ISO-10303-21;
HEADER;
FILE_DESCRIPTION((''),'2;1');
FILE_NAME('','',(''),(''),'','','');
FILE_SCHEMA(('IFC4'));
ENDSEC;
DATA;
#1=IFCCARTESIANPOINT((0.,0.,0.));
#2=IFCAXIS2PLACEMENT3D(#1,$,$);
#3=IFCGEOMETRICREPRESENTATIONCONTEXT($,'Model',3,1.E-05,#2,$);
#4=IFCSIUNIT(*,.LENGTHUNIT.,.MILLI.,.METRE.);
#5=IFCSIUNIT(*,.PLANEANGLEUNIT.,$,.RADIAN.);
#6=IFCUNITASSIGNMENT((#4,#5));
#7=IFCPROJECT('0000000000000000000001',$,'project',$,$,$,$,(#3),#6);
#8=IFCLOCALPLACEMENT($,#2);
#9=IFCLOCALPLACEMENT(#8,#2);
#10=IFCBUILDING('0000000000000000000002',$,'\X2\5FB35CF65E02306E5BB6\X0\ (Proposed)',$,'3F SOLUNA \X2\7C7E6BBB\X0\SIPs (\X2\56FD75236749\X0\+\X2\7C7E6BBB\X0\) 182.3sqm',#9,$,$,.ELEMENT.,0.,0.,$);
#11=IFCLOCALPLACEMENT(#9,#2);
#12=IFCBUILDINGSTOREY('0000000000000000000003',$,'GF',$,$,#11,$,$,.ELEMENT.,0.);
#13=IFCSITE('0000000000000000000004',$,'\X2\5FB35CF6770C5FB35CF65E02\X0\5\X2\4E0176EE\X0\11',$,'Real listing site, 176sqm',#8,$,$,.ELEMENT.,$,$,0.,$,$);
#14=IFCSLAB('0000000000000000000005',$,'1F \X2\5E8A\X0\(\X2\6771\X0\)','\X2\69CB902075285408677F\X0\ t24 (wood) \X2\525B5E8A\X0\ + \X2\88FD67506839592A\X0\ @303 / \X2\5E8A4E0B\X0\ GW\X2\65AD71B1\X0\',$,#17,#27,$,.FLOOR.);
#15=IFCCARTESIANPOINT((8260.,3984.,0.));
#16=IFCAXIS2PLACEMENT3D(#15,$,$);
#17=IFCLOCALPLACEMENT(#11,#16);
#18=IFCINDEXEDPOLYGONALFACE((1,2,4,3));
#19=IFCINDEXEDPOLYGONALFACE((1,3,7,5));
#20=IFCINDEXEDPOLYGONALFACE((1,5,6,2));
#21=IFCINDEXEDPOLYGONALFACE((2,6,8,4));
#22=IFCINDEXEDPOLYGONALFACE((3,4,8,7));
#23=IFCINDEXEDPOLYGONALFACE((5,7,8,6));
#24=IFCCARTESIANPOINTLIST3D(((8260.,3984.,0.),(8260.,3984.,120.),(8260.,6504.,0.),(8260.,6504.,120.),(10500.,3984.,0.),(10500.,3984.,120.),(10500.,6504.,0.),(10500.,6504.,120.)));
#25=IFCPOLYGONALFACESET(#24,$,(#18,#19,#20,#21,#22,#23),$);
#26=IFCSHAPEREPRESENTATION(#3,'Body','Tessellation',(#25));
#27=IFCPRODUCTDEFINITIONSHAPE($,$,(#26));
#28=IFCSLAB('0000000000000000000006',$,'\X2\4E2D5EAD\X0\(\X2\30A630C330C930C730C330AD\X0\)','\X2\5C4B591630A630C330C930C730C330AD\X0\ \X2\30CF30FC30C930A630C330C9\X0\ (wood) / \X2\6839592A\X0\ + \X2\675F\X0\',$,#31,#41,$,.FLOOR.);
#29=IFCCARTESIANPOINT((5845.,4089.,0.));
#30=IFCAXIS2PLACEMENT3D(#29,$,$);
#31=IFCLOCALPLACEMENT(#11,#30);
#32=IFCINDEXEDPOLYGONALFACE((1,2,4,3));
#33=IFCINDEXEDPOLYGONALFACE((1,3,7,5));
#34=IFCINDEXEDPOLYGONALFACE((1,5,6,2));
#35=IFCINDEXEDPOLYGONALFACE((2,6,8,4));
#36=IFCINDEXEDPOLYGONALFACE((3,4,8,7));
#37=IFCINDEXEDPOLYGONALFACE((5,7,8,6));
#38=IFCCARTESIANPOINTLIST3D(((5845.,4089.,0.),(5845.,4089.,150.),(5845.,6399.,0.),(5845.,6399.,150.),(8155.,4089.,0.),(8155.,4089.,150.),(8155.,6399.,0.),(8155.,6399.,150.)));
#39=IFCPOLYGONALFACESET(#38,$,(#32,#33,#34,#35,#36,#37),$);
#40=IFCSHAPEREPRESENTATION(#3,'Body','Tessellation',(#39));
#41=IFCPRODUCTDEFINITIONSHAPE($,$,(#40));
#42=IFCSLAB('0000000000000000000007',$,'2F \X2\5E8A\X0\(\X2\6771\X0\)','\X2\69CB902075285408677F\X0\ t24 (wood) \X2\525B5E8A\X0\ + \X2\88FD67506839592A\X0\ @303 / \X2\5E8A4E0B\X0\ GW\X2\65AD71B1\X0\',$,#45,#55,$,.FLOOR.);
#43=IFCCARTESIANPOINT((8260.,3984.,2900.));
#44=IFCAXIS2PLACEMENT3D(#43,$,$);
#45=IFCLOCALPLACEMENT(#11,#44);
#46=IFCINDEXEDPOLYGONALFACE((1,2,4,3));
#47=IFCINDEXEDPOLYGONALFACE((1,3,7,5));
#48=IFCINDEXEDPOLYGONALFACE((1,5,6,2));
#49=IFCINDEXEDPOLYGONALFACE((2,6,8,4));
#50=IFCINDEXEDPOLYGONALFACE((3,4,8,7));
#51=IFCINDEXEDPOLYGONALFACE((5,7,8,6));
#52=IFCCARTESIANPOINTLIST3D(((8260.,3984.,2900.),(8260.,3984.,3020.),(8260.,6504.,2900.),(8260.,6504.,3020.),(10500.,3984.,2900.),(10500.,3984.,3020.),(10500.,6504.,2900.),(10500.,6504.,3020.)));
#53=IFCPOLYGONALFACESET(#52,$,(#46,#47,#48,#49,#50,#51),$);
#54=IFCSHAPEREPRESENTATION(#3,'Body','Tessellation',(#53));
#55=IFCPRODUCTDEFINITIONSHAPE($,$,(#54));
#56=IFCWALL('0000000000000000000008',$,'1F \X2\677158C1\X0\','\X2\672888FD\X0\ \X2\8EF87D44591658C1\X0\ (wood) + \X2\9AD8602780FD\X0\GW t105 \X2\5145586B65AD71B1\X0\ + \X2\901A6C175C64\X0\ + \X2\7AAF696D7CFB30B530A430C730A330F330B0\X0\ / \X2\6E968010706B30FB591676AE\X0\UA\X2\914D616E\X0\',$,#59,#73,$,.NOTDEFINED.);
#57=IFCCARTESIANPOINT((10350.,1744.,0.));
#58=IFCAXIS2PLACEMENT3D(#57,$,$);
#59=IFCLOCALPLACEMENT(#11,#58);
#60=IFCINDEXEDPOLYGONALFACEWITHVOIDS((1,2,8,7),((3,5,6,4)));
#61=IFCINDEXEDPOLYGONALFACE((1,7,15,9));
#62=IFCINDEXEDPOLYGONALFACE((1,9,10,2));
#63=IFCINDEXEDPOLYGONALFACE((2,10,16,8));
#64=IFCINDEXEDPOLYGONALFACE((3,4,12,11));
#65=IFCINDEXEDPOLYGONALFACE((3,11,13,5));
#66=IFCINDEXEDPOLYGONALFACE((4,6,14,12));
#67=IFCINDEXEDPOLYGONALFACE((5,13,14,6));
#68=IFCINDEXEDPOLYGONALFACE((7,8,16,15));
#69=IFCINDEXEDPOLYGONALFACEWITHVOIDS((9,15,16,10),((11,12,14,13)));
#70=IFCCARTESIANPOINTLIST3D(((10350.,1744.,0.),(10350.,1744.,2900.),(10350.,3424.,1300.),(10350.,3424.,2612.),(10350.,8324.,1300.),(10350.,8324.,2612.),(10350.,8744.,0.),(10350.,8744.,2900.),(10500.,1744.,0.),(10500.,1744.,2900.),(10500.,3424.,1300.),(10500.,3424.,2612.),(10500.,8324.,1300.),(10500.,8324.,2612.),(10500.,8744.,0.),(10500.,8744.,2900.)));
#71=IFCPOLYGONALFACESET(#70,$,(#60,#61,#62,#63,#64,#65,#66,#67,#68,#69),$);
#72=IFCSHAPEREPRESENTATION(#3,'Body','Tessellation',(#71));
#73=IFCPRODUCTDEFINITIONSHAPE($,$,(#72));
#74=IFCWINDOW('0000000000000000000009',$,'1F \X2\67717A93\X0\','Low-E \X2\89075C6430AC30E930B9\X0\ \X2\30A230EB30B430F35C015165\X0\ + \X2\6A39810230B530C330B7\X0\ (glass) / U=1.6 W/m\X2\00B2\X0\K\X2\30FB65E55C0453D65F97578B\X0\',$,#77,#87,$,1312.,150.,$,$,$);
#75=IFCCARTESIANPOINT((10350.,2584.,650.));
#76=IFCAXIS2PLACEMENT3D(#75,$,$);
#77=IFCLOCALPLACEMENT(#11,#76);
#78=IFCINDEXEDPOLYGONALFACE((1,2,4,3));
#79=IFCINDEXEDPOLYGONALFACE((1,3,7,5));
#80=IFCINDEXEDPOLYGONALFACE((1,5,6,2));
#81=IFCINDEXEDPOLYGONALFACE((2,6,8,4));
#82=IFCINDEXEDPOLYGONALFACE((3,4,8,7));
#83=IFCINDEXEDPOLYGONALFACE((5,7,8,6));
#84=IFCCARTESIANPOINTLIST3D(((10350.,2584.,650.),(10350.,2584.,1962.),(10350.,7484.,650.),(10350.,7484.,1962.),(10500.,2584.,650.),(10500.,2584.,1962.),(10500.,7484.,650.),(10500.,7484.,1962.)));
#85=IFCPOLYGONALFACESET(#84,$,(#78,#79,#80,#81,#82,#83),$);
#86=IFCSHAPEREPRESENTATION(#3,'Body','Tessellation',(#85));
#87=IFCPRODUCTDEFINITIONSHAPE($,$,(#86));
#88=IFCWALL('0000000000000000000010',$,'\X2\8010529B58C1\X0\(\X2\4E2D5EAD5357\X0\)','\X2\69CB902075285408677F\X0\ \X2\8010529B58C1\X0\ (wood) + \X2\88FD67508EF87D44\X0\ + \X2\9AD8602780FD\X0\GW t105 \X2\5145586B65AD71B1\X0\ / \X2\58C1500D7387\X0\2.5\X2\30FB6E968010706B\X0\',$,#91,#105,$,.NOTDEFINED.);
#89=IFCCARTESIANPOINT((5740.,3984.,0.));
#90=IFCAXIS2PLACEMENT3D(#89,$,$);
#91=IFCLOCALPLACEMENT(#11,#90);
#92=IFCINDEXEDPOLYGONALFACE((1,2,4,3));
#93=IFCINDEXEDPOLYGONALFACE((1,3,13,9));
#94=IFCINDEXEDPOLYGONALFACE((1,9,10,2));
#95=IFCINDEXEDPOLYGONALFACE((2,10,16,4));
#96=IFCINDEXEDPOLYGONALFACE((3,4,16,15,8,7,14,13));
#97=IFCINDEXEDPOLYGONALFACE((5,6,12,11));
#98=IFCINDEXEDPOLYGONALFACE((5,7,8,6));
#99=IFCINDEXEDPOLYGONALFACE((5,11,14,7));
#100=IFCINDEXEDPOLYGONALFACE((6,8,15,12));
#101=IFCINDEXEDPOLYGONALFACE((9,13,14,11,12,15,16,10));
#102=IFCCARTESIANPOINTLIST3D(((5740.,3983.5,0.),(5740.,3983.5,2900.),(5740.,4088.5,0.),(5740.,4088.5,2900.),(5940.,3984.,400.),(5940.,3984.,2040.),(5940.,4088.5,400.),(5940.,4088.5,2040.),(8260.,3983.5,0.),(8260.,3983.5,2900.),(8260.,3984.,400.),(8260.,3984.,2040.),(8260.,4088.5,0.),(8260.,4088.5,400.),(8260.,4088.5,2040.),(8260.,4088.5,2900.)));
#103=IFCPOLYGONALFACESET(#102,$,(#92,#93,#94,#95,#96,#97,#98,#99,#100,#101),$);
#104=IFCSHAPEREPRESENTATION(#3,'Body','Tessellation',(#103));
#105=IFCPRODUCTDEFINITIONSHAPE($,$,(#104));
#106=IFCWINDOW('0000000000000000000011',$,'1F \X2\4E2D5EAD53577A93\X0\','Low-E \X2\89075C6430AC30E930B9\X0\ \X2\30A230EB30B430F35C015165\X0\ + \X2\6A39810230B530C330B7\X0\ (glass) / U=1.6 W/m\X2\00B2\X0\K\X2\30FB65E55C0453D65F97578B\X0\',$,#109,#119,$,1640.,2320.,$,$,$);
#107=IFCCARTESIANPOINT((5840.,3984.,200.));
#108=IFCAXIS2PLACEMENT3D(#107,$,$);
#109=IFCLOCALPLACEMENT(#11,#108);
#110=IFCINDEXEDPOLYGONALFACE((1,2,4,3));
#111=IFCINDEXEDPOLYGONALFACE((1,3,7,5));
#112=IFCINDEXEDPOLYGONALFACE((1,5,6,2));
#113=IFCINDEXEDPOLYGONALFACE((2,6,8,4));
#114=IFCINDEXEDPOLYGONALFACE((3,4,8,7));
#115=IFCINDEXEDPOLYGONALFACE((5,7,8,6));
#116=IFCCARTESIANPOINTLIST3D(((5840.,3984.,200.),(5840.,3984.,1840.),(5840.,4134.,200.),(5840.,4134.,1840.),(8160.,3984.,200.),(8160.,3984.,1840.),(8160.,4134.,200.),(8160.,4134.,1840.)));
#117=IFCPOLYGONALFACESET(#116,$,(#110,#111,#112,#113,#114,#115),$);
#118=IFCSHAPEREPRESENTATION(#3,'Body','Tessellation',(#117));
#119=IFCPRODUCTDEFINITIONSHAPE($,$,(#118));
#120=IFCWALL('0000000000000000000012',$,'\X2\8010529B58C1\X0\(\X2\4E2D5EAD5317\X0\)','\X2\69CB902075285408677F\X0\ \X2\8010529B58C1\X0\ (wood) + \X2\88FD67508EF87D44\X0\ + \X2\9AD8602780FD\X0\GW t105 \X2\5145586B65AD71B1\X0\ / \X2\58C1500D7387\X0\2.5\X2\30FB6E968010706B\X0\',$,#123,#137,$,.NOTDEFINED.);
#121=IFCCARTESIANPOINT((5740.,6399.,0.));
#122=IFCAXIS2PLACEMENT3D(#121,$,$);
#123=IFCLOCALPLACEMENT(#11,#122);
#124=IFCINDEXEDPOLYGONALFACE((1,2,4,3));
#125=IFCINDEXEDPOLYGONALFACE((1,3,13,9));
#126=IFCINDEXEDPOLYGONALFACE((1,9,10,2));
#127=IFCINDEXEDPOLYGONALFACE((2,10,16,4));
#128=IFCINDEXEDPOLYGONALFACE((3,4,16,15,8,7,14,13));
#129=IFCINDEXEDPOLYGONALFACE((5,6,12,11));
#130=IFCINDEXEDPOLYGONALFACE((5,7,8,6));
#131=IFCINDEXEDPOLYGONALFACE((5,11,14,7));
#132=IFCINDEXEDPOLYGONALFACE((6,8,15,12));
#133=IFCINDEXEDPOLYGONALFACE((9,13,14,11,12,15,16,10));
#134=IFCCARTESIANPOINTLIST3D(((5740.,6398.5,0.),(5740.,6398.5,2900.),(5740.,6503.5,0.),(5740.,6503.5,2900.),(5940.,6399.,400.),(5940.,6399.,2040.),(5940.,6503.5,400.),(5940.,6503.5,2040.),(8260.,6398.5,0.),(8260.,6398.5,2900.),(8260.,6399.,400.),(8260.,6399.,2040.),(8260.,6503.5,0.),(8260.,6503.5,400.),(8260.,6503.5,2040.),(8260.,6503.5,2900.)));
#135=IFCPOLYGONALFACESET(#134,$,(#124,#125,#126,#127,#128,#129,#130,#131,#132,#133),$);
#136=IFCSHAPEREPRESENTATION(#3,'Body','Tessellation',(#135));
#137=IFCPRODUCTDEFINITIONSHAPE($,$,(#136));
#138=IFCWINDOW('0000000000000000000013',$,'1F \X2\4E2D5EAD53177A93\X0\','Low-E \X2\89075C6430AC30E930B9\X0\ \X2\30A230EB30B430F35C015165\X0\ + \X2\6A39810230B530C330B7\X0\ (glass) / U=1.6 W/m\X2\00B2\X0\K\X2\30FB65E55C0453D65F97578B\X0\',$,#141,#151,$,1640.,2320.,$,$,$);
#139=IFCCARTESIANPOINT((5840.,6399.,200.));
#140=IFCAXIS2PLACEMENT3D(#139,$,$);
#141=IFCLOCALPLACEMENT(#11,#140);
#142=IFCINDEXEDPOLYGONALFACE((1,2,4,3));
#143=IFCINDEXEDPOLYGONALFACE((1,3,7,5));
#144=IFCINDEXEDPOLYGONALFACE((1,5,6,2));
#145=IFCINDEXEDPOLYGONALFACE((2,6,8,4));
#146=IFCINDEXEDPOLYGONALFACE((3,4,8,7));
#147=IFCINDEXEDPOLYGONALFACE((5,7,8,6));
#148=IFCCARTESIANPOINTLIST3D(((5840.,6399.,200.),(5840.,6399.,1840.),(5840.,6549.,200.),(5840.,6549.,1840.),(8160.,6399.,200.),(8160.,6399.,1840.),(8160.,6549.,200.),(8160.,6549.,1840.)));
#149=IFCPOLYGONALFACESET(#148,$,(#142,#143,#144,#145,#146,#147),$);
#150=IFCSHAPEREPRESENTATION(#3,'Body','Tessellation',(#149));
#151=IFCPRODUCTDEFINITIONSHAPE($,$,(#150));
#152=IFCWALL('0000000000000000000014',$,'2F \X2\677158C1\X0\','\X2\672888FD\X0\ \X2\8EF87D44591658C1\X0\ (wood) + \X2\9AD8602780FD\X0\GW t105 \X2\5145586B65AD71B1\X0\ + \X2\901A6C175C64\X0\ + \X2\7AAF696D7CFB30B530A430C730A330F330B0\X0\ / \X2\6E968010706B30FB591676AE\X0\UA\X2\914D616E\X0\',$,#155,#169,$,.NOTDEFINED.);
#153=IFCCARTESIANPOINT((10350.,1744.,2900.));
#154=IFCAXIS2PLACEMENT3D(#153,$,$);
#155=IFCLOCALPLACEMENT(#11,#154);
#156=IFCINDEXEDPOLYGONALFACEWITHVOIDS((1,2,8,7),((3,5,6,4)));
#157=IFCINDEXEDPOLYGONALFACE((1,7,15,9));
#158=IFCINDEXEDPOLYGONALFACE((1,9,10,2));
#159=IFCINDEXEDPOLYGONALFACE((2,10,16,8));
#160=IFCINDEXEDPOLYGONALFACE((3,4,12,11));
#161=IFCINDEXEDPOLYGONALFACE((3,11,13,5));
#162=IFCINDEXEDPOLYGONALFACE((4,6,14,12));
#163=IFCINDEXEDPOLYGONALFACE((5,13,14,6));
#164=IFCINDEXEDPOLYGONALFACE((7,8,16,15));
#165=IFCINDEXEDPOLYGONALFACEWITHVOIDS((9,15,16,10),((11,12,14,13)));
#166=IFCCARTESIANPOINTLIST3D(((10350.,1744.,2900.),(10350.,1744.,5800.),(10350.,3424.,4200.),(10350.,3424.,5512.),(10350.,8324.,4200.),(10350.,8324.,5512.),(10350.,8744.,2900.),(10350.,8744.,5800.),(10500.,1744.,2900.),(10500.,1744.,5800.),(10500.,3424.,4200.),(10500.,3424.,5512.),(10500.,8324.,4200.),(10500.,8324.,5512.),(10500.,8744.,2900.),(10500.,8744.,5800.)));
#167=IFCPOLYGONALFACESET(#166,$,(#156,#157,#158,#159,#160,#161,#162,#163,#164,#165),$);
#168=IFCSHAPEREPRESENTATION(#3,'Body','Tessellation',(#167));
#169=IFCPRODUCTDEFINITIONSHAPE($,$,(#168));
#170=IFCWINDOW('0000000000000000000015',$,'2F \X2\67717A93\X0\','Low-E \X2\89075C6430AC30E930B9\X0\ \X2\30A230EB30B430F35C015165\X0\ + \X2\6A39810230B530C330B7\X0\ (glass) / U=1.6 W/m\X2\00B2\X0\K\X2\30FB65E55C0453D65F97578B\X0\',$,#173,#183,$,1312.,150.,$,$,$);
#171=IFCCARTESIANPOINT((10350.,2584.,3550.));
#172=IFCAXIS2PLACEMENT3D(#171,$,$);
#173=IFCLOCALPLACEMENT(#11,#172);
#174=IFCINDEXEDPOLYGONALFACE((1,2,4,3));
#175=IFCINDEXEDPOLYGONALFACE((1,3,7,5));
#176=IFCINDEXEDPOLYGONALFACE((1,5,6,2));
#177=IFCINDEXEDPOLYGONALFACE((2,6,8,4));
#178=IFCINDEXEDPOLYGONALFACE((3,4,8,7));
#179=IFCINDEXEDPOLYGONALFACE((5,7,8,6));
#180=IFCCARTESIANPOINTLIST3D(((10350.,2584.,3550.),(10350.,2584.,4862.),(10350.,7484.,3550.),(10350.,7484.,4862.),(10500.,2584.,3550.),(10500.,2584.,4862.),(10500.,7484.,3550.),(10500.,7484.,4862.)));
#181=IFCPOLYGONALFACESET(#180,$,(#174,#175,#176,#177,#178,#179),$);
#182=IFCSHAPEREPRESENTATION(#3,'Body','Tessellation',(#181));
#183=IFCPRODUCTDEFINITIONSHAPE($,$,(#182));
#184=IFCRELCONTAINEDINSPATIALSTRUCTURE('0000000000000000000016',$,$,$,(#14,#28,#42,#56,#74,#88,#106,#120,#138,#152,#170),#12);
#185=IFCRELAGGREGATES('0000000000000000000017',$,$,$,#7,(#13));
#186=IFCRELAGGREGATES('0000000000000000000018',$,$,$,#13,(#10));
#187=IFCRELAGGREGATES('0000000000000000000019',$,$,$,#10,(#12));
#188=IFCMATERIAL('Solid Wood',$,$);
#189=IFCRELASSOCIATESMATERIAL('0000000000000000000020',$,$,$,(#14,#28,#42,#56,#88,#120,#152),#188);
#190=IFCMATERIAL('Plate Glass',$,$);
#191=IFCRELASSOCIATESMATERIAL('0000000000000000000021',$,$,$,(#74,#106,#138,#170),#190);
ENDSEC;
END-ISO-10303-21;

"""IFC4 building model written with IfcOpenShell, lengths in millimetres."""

from ifc_helpers import new_model, si_unit, frame, frame_2d, origin, place, context, project, spatial, rectangle, extrude, material, element, fill, save


model = new_model("IFC4")

# Units and contexts
model_context = context("Model", 3, precision=1e-05, world=origin())
ifc_project = project(units=[si_unit("LENGTHUNIT", "METRE", prefix="MILLI"), si_unit("PLANEANGLEUNIT", "RADIAN")], contexts=[model_context])

# Site, building, storey
site_placement = place(None, origin())
site = spatial("IfcSite", under=ifc_project, at=site_placement, Name="徳島県徳島市5丁目11", ObjectType="Real listing site, 176sqm", CompositionType="ELEMENT", RefElevation=0.0)
building_placement = place(site_placement, origin())
building = spatial("IfcBuilding", under=site, at=building_placement, Name="徳島市の家 (Proposed)", ObjectType="3F SOLUNA 籾殻SIPs (国産杉+籾殻) 182.3sqm", CompositionType="ELEMENT", ElevationOfRefHeight=0.0, ElevationOfTerrain=0.0)
storey_placement = place(building_placement, origin())
storey = spatial("IfcBuildingStorey", under=building, at=storey_placement, Name="GF", CompositionType="ELEMENT", Elevation=0.0)

# Slabs
ifc_material_1 = material(Name="Solid Wood")
slab_1_placement = place(storey_placement, frame((8260.0, 3984.0, 0.0)))
element("IfcSlab", 1, at=slab_1_placement, inside=storey, material=ifc_material_1, Name="1F 床(東)", Description="構造用合板 t24 (wood) 剛床 + 製材根太 @303 / 床下 GW断熱", PredefinedType="FLOOR", context=model_context, shape_type="SweptSolid", body=[
    extrude(rectangle(XDim=2240.0, YDim=2520.0, at=frame_2d((1120.0, 1260.0))), frame((8260.0, 3984.0, 0.0)), (0.0, 0.0, 1.0), 120.0),
])
slab_2_placement = place(storey_placement, frame((5845.0, 4089.0, 0.0)))
element("IfcSlab", 2, at=slab_2_placement, inside=storey, material=ifc_material_1, Name="中庭(ウッドデッキ)", Description="屋外ウッドデッキ ハードウッド (wood) / 根太 + 束", PredefinedType="FLOOR", context=model_context, shape_type="SweptSolid", body=[
    extrude(rectangle(XDim=2310.0, YDim=2310.0, at=frame_2d((1155.0, 1155.0))), frame((5845.0, 4089.0, 0.0)), (0.0, 0.0, 1.0), 150.0),
])
slab_3_placement = place(storey_placement, frame((8260.0, 3984.0, 2900.0)))
element("IfcSlab", 3, at=slab_3_placement, inside=storey, material=ifc_material_1, Name="2F 床(東)", Description="構造用合板 t24 (wood) 剛床 + 製材根太 @303 / 床下 GW断熱", PredefinedType="FLOOR", context=model_context, shape_type="SweptSolid", body=[
    extrude(rectangle(XDim=2240.0, YDim=2520.0, at=frame_2d((1120.0, 1260.0))), frame((8260.0, 3984.0, 2900.0)), (0.0, 0.0, 1.0), 120.0),
])

# Walls, openings, windows
wall_1_placement = place(storey_placement, frame((10350.0, 1744.0, 0.0)))
wall_1 = element("IfcWall", 4, at=wall_1_placement, inside=storey, material=ifc_material_1, Name="1F 東壁", Description="木製 軸組外壁 (wood) + 高性能GW t105 充填断熱 + 通気層 + 窯業系サイディング / 準耐火・外皮UA配慮", PredefinedType="NOTDEFINED", context=model_context, shape_type="SweptSolid", body=[
    extrude(rectangle(XDim=150.0, YDim=7000.0, at=frame_2d((75.0, 3500.0))), frame((10350.0, 1744.0, 0.0)), (0.0, 0.0, 1.0), 2900.0),
])
opening_1_placement = place(storey_placement, frame((10350.0, 2584.0, 650.0)))
opening_1 = element("IfcOpeningElement", 5, at=opening_1_placement, cuts=wall_1, PredefinedType="NOTDEFINED", context=model_context, shape_type="SweptSolid", body=[
    extrude(rectangle(XDim=150.0, YDim=4900.0, at=frame_2d((75.0, 2450.0))), frame((10350.0, 2584.0, 650.0)), (0.0, 0.0, 1.0), 1312.0),
])
ifc_material_2 = material(Name="Plate Glass")
window_1_placement = place(storey_placement, frame((10350.0, 2584.0, 650.0)))
window_1 = element("IfcWindow", 6, at=window_1_placement, inside=storey, material=ifc_material_2, Name="1F 東窓", Description="Low-E 複層ガラス アルゴン封入 + 樹脂サッシ (glass) / U=1.6 W/m²K・日射取得型", OverallHeight=1312.0, OverallWidth=150.0, context=model_context, shape_type="SweptSolid", body=[
    extrude(rectangle(XDim=150.0, YDim=4900.0, at=frame_2d((75.0, 2450.0))), frame((10350.0, 2584.0, 650.0)), (0.0, 0.0, 1.0), 1312.0),
])
fill(opening_1, window_1)
wall_2_placement = place(storey_placement, frame((5740.0, 3984.0, 0.0)))
wall_2 = element("IfcWall", 7, at=wall_2_placement, inside=storey, material=ifc_material_1, Name="耐力壁(中庭南)", Description="構造用合板 耐力壁 (wood) + 製材軸組 + 高性能GW t105 充填断熱 / 壁倍率2.5・準耐火", PredefinedType="NOTDEFINED", context=model_context, shape_type="SweptSolid", body=[
    extrude(rectangle(XDim=2520.0, YDim=105.0, at=frame_2d((1260.0, 52.0))), frame((5740.0, 3984.0, 0.0)), (0.0, 0.0, 1.0), 2900.0),
])
opening_2_placement = place(storey_placement, frame((5840.0, 3984.0, 200.0)))
opening_2 = element("IfcOpeningElement", 8, at=opening_2_placement, cuts=wall_2, PredefinedType="NOTDEFINED", context=model_context, shape_type="SweptSolid", body=[
    extrude(rectangle(XDim=2320.0, YDim=150.0, at=frame_2d((1160.0, 75.0))), frame((5840.0, 3984.0, 200.0)), (0.0, 0.0, 1.0), 1640.0),
])
window_2_placement = place(storey_placement, frame((5840.0, 3984.0, 200.0)))
window_2 = element("IfcWindow", 9, at=window_2_placement, inside=storey, material=ifc_material_2, Name="1F 中庭南窓", Description="Low-E 複層ガラス アルゴン封入 + 樹脂サッシ (glass) / U=1.6 W/m²K・日射取得型", OverallHeight=1640.0, OverallWidth=2320.0, context=model_context, shape_type="SweptSolid", body=[
    extrude(rectangle(XDim=2320.0, YDim=150.0, at=frame_2d((1160.0, 75.0))), frame((5840.0, 3984.0, 200.0)), (0.0, 0.0, 1.0), 1640.0),
])
fill(opening_2, window_2)
wall_3_placement = place(storey_placement, frame((5740.0, 6399.0, 0.0)))
wall_3 = element("IfcWall", 10, at=wall_3_placement, inside=storey, material=ifc_material_1, Name="耐力壁(中庭北)", Description="構造用合板 耐力壁 (wood) + 製材軸組 + 高性能GW t105 充填断熱 / 壁倍率2.5・準耐火", PredefinedType="NOTDEFINED", context=model_context, shape_type="SweptSolid", body=[
    extrude(rectangle(XDim=2520.0, YDim=105.0, at=frame_2d((1260.0, 52.0))), frame((5740.0, 6399.0, 0.0)), (0.0, 0.0, 1.0), 2900.0),
])
opening_3_placement = place(storey_placement, frame((5840.0, 6399.0, 200.0)))
opening_3 = element("IfcOpeningElement", 11, at=opening_3_placement, cuts=wall_3, PredefinedType="NOTDEFINED", context=model_context, shape_type="SweptSolid", body=[
    extrude(rectangle(XDim=2320.0, YDim=150.0, at=frame_2d((1160.0, 75.0))), frame((5840.0, 6399.0, 200.0)), (0.0, 0.0, 1.0), 1640.0),
])
window_3_placement = place(storey_placement, frame((5840.0, 6399.0, 200.0)))
window_3 = element("IfcWindow", 12, at=window_3_placement, inside=storey, material=ifc_material_2, Name="1F 中庭北窓", Description="Low-E 複層ガラス アルゴン封入 + 樹脂サッシ (glass) / U=1.6 W/m²K・日射取得型", OverallHeight=1640.0, OverallWidth=2320.0, context=model_context, shape_type="SweptSolid", body=[
    extrude(rectangle(XDim=2320.0, YDim=150.0, at=frame_2d((1160.0, 75.0))), frame((5840.0, 6399.0, 200.0)), (0.0, 0.0, 1.0), 1640.0),
])
fill(opening_3, window_3)

# Wall, opening, window
wall_4_placement = place(storey_placement, frame((10350.0, 1744.0, 2900.0)))
wall_4 = element("IfcWall", 13, at=wall_4_placement, inside=storey, material=ifc_material_1, Name="2F 東壁", Description="木製 軸組外壁 (wood) + 高性能GW t105 充填断熱 + 通気層 + 窯業系サイディング / 準耐火・外皮UA配慮", PredefinedType="NOTDEFINED", context=model_context, shape_type="SweptSolid", body=[
    extrude(rectangle(XDim=150.0, YDim=7000.0, at=frame_2d((75.0, 3500.0))), frame((10350.0, 1744.0, 2900.0)), (0.0, 0.0, 1.0), 2900.0),
])
opening_4_placement = place(storey_placement, frame((10350.0, 2584.0, 3550.0)))
opening_4 = element("IfcOpeningElement", 14, at=opening_4_placement, cuts=wall_4, PredefinedType="NOTDEFINED", context=model_context, shape_type="SweptSolid", body=[
    extrude(rectangle(XDim=150.0, YDim=4900.0, at=frame_2d((75.0, 2450.0))), frame((10350.0, 2584.0, 3550.0)), (0.0, 0.0, 1.0), 1312.0),
])
window_4_placement = place(storey_placement, frame((10350.0, 2584.0, 3550.0)))
window_4 = element("IfcWindow", 15, at=window_4_placement, inside=storey, material=ifc_material_2, Name="2F 東窓", Description="Low-E 複層ガラス アルゴン封入 + 樹脂サッシ (glass) / U=1.6 W/m²K・日射取得型", OverallHeight=1312.0, OverallWidth=150.0, context=model_context, shape_type="SweptSolid", body=[
    extrude(rectangle(XDim=150.0, YDim=4900.0, at=frame_2d((75.0, 2450.0))), frame((10350.0, 2584.0, 3550.0)), (0.0, 0.0, 1.0), 1312.0),
])
fill(opening_4, window_4)

save(model, "model.ifc")
